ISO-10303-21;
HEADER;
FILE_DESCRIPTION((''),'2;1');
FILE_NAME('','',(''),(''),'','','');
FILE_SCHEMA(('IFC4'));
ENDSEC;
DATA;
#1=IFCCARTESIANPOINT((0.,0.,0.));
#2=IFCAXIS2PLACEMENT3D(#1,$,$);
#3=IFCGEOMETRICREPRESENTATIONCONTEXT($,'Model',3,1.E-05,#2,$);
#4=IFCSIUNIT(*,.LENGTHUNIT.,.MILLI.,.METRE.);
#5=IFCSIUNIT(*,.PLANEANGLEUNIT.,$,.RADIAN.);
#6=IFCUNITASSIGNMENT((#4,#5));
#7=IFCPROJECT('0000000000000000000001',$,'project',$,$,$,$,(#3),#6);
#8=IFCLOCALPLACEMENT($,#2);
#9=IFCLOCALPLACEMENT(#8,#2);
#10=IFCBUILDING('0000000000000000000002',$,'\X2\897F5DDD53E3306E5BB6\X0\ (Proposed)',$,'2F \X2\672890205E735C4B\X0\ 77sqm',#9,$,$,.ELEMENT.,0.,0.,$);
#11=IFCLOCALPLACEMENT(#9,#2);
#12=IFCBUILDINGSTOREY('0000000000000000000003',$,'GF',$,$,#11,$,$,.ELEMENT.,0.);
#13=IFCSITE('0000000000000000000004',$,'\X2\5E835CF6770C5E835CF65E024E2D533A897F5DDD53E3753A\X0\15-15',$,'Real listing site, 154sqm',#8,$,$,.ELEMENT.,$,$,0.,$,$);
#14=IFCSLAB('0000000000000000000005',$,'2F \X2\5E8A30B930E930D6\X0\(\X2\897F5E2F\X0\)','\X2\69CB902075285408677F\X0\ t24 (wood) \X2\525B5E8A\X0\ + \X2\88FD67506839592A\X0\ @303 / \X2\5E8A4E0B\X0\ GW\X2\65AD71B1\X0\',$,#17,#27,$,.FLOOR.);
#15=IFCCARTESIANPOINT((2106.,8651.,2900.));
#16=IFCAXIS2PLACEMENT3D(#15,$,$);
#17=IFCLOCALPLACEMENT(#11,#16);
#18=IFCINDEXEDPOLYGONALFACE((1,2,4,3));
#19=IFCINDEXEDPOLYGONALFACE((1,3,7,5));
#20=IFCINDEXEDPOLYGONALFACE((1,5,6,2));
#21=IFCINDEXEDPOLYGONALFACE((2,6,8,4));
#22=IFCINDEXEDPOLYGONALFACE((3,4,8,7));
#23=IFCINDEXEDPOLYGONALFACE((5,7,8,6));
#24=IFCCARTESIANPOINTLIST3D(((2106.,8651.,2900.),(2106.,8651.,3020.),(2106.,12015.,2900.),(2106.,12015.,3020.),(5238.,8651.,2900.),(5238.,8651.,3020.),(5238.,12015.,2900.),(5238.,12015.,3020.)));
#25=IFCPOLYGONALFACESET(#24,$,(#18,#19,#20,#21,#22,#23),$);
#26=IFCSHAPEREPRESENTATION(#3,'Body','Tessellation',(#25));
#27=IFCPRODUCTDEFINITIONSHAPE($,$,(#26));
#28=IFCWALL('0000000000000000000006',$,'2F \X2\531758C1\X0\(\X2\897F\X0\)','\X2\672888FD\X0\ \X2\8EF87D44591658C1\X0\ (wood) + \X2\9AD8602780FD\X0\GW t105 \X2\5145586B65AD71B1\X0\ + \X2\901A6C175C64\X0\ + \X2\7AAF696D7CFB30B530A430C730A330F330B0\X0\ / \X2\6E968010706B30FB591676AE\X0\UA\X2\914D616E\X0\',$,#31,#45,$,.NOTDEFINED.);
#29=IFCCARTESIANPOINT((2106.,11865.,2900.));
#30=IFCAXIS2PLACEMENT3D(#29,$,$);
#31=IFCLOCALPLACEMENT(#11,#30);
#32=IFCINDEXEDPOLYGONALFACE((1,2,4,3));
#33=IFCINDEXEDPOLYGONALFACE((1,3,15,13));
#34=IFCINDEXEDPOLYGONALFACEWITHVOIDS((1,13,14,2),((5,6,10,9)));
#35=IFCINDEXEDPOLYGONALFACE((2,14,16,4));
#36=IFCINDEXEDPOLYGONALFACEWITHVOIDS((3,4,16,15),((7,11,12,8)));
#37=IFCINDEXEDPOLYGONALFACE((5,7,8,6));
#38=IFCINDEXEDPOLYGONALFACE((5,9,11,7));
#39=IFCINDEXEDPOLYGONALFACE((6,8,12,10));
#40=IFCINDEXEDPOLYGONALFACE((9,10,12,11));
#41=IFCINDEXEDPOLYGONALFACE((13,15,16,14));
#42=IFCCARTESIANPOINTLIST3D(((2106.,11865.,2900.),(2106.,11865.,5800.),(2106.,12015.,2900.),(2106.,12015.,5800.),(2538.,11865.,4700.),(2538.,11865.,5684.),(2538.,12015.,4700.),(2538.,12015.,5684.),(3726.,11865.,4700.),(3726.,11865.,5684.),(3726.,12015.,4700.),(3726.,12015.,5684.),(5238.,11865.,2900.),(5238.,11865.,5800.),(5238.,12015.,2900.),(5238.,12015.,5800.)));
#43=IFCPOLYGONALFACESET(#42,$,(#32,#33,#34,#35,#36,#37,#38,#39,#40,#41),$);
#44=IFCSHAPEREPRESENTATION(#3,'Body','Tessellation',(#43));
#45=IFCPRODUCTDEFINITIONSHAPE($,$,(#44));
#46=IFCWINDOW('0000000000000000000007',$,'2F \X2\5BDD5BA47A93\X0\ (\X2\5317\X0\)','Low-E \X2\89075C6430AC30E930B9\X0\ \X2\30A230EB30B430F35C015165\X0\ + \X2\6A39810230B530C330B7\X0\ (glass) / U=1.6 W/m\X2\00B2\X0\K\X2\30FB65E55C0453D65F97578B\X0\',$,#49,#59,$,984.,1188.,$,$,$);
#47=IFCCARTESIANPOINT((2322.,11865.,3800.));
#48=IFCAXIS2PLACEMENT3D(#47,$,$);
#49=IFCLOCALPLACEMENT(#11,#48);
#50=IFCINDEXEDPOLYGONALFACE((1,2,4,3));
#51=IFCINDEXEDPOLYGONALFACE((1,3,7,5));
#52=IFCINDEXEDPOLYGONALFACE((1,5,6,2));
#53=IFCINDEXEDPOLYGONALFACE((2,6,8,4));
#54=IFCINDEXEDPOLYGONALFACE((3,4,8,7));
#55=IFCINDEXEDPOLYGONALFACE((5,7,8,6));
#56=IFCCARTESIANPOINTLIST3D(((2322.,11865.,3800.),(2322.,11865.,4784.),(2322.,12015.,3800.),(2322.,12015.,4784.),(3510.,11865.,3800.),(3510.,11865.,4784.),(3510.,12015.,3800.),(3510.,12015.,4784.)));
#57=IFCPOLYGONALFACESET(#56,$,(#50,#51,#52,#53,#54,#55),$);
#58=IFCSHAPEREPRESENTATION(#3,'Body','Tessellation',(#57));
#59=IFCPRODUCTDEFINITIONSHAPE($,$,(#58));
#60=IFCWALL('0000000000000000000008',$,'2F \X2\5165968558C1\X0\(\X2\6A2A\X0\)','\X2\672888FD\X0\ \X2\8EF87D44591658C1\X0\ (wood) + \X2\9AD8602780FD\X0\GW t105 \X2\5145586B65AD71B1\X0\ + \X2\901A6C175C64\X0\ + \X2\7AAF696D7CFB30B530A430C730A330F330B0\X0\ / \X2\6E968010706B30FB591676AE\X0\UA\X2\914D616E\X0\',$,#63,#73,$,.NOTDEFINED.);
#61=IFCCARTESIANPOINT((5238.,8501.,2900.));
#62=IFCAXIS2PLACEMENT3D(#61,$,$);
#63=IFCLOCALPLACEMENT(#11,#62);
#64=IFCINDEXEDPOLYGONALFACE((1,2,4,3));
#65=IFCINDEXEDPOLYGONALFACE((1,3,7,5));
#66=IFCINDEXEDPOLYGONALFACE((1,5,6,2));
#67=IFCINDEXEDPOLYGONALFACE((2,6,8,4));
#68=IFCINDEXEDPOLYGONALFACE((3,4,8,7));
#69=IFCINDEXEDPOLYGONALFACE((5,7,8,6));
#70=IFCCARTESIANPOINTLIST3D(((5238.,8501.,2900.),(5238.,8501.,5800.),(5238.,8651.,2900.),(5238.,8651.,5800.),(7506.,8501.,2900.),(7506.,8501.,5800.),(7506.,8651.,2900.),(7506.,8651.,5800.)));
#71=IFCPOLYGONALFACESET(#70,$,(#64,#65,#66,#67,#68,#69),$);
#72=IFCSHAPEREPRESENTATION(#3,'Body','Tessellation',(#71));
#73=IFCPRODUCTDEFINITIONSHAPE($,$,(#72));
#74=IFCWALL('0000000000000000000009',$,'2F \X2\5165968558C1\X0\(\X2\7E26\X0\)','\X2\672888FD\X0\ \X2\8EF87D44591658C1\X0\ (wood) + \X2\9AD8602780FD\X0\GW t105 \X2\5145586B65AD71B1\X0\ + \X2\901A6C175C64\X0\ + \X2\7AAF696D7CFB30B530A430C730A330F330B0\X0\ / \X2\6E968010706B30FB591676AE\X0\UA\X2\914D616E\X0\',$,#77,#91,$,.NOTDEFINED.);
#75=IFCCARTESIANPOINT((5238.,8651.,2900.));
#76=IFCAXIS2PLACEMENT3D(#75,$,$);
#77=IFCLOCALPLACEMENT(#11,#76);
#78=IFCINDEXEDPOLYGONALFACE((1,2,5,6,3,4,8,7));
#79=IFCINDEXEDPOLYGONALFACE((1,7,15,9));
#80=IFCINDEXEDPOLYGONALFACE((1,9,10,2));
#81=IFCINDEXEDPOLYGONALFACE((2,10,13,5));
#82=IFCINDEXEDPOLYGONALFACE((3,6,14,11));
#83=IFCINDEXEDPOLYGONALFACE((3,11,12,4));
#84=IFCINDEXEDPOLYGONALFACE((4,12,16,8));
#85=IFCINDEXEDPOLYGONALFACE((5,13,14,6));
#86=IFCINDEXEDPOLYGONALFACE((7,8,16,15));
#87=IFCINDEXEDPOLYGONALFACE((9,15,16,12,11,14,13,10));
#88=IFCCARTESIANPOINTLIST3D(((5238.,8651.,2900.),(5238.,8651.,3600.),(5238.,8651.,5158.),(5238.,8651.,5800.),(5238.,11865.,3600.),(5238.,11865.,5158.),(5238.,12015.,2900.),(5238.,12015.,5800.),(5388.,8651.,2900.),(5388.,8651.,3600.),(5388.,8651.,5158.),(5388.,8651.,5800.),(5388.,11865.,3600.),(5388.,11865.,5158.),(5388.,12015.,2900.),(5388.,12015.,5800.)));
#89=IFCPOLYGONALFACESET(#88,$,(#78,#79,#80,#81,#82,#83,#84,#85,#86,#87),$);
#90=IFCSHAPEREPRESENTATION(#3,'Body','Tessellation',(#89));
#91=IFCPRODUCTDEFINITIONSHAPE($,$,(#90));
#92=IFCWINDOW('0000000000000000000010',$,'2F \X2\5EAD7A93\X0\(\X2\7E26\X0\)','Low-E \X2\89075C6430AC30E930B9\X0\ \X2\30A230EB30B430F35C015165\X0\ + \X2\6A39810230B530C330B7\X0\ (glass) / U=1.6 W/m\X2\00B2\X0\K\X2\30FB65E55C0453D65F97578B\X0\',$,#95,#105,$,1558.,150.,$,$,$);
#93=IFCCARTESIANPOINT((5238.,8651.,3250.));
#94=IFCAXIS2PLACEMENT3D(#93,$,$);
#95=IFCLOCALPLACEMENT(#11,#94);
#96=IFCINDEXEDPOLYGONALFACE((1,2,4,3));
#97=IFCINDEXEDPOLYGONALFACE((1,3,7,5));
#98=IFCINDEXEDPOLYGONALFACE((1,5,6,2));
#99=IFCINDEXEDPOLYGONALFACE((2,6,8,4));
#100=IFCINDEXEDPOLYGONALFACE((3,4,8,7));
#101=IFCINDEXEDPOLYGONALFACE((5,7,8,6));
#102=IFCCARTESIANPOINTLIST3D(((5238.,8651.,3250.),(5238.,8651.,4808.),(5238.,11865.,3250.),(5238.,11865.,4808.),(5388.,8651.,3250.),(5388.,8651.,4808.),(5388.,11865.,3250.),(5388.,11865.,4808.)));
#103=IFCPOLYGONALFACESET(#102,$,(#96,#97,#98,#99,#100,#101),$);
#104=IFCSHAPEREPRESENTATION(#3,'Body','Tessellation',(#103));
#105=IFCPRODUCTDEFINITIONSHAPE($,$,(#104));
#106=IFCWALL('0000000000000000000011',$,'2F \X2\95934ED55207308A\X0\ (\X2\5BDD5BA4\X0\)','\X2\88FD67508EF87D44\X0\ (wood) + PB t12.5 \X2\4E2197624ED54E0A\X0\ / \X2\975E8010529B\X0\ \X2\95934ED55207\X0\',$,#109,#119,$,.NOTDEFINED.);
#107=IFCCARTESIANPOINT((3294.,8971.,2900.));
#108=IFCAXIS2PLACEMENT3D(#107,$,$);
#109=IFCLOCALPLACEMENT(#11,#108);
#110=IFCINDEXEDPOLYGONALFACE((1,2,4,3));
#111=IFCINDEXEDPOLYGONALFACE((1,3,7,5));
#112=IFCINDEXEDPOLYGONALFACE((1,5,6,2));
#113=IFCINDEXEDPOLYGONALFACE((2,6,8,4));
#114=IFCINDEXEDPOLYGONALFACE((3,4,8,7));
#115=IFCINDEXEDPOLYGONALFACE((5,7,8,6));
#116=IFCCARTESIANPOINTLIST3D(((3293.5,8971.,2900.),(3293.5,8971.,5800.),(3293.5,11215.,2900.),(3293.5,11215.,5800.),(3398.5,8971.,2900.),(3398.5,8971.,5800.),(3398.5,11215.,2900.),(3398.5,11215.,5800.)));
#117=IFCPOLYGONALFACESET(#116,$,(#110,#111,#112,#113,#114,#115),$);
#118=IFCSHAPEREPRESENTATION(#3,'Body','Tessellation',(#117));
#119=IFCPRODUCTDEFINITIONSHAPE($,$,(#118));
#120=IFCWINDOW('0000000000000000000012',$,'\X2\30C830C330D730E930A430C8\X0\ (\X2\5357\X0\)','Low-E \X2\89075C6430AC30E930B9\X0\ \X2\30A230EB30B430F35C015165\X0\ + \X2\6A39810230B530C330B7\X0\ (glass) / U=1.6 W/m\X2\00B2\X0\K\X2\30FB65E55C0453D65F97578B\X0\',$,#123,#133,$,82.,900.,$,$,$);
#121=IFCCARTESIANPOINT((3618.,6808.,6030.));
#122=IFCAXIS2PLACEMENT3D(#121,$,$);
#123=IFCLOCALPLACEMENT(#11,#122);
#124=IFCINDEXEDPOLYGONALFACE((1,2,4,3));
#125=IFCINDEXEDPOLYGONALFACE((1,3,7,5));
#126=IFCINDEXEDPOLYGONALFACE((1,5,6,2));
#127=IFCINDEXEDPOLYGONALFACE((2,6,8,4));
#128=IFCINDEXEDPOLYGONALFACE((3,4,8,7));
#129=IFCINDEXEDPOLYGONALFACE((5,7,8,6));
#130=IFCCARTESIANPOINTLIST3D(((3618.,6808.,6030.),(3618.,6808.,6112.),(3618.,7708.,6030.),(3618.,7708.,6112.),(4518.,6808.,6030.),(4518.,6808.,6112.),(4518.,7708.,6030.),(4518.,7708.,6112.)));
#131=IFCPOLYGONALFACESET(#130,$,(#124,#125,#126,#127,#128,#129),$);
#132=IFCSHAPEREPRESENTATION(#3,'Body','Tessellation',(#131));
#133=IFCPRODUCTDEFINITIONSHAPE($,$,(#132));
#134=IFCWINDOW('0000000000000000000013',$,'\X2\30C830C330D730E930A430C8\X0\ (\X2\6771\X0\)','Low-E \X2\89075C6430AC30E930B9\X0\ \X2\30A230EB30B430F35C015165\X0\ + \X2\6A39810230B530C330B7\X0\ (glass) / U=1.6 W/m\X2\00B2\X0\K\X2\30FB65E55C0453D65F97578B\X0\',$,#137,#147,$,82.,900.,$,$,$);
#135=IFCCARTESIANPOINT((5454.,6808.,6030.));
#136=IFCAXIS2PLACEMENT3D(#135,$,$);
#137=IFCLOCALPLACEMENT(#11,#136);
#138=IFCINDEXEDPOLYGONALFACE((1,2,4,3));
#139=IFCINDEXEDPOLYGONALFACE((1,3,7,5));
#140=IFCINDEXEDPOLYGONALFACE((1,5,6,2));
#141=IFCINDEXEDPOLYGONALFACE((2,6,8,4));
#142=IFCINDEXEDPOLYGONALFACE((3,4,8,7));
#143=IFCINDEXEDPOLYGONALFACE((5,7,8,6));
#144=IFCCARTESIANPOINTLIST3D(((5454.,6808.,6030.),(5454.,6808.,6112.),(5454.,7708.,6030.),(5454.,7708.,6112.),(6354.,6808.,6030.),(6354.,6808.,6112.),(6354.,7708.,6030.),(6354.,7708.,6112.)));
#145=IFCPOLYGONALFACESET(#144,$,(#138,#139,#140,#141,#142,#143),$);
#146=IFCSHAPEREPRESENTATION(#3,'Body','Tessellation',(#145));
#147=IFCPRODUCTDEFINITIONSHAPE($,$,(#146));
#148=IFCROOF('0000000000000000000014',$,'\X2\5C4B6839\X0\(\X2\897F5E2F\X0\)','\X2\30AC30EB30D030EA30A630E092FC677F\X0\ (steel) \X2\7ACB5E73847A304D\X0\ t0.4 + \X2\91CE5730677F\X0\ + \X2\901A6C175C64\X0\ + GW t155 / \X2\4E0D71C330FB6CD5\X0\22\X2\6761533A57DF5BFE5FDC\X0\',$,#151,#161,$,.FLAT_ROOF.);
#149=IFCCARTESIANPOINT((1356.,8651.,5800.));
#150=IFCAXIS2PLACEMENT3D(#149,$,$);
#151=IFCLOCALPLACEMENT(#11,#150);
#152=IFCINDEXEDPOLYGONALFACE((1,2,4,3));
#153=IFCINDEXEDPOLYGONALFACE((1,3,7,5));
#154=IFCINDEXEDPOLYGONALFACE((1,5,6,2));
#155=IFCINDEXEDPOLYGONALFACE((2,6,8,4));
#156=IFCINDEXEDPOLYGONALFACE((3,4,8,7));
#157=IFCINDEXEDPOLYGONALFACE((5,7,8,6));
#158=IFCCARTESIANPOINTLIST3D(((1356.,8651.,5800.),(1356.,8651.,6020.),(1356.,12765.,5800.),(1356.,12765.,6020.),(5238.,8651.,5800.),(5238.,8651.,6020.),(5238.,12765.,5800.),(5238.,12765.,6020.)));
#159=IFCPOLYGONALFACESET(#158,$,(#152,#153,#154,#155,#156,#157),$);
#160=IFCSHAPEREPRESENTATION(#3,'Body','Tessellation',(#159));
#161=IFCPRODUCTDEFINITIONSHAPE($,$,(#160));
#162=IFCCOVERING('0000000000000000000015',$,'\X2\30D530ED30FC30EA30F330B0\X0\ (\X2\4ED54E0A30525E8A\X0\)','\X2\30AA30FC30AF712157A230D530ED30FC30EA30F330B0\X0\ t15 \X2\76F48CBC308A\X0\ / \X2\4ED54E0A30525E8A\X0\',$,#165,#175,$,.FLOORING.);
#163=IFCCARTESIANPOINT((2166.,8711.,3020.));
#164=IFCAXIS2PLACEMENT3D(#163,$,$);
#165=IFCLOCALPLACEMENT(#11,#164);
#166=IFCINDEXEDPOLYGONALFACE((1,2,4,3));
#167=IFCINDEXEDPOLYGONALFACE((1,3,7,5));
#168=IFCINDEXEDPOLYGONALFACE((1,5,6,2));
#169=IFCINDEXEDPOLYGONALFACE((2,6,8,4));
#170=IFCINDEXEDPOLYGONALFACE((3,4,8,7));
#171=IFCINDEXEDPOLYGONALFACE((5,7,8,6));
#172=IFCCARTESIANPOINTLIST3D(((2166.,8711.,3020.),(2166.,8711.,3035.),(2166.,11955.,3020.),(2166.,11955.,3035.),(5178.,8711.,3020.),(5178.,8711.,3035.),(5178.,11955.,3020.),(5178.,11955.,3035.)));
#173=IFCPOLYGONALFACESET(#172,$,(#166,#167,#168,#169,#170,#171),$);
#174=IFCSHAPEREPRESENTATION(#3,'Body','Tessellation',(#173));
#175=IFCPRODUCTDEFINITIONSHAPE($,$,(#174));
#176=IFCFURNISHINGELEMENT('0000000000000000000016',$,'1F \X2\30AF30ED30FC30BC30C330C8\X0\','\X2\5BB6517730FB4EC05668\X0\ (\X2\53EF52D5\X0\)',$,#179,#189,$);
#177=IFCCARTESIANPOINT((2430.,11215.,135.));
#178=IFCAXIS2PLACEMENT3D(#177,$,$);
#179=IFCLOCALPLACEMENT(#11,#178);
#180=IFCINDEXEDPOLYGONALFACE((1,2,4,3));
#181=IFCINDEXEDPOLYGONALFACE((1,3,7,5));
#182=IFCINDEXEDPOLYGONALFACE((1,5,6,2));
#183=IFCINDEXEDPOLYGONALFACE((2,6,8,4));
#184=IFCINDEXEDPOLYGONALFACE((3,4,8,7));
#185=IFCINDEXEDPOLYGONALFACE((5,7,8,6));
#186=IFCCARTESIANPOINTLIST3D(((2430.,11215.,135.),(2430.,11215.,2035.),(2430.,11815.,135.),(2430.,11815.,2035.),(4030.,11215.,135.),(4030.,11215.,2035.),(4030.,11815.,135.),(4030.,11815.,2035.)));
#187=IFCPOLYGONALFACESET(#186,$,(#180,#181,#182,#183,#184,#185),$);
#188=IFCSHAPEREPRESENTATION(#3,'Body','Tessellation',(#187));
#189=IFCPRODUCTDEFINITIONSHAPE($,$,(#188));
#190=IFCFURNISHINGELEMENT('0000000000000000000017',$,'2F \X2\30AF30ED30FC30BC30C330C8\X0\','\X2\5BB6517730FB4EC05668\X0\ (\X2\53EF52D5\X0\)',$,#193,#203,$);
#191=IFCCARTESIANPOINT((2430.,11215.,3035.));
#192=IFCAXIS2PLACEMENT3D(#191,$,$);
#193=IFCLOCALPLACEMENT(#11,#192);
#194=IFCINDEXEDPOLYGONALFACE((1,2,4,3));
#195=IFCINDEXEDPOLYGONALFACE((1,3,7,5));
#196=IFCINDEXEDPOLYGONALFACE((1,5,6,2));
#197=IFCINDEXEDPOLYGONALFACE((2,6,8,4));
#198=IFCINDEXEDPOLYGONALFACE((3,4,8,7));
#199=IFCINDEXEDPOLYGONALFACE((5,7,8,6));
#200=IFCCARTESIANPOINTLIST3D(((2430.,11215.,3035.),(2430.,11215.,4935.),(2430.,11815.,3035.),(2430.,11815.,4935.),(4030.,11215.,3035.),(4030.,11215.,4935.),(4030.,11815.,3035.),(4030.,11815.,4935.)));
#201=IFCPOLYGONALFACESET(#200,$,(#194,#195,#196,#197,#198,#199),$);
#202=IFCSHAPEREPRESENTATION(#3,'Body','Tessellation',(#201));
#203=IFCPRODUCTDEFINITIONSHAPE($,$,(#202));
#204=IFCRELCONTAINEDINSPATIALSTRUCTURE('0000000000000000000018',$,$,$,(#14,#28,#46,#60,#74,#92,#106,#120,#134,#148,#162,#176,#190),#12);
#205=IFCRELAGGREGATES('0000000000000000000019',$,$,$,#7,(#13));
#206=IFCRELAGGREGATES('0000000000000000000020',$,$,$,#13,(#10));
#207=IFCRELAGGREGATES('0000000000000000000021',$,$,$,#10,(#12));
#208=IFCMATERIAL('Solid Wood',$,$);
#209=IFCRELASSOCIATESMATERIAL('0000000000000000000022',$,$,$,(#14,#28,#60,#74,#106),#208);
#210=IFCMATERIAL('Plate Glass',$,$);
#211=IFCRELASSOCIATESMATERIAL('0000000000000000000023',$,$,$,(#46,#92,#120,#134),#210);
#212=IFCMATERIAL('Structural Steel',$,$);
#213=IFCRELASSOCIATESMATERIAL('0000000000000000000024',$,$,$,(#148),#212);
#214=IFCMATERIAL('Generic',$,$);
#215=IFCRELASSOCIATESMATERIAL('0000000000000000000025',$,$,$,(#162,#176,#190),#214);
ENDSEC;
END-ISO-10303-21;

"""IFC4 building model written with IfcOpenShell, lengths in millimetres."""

from ifc_helpers import new_model, si_unit, frame, frame_2d, origin, place, context, project, spatial, rectangle, extrude, material, element, fill, save


model = new_model("IFC4")

# Units and contexts
model_context = context("Model", 3, precision=1e-05, world=origin())
ifc_project = project(units=[si_unit("LENGTHUNIT", "METRE", prefix="MILLI"), si_unit("PLANEANGLEUNIT", "RADIAN")], contexts=[model_context])

# Site, building, storey
site_placement = place(None, origin())
site = spatial("IfcSite", under=ifc_project, at=site_placement, Name="広島県広島市中区西川口町15-15", ObjectType="Real listing site, 154sqm", CompositionType="ELEMENT", RefElevation=0.0)
building_placement = place(site_placement, origin())
building = spatial("IfcBuilding", under=site, at=building_placement, Name="西川口の家 (Proposed)", ObjectType="2F 木造平屋 77sqm", CompositionType="ELEMENT", ElevationOfRefHeight=0.0, ElevationOfTerrain=0.0)
storey_placement = place(building_placement, origin())
storey = spatial("IfcBuildingStorey", under=building, at=storey_placement, Name="GF", CompositionType="ELEMENT", Elevation=0.0)

# Slab
ifc_material_1 = material(Name="Solid Wood")
slab_placement = place(storey_placement, frame((2106.0, 8651.0, 2900.0)))
element("IfcSlab", 1, at=slab_placement, inside=storey, material=ifc_material_1, Name="2F 床スラブ(西帯)", Description="構造用合板 t24 (wood) 剛床 + 製材根太 @303 / 床下 GW断熱", PredefinedType="FLOOR", context=model_context, shape_type="SweptSolid", body=[
    extrude(rectangle(XDim=3132.0, YDim=3364.0, at=frame_2d((1566.0, 1682.0))), frame((2106.0, 8651.0, 2900.0)), (0.0, 0.0, 1.0), 120.0),
])

# Wall, opening, window
wall_1_placement = place(storey_placement, frame((2106.0, 11865.0, 2900.0)))
wall_1 = element("IfcWall", 2, at=wall_1_placement, inside=storey, material=ifc_material_1, Name="2F 北壁(西)", Description="木製 軸組外壁 (wood) + 高性能GW t105 充填断熱 + 通気層 + 窯業系サイディング / 準耐火・外皮UA配慮", PredefinedType="NOTDEFINED", context=model_context, shape_type="SweptSolid", body=[
    extrude(rectangle(XDim=3132.0, YDim=150.0, at=frame_2d((1566.0, 75.0))), frame((2106.0, 11865.0, 2900.0)), (0.0, 0.0, 1.0), 2900.0),
])
opening_1_placement = place(storey_placement, frame((2322.0, 11865.0, 3800.0)))
opening_1 = element("IfcOpeningElement", 3, at=opening_1_placement, cuts=wall_1, PredefinedType="NOTDEFINED", context=model_context, shape_type="SweptSolid", body=[
    extrude(rectangle(XDim=1188.0, YDim=150.0, at=frame_2d((594.0, 75.0))), frame((2322.0, 11865.0, 3800.0)), (0.0, 0.0, 1.0), 984.0),
])
ifc_material_2 = material(Name="Plate Glass")
window_1_placement = place(storey_placement, frame((2322.0, 11865.0, 3800.0)))
window_1 = element("IfcWindow", 4, at=window_1_placement, inside=storey, material=ifc_material_2, Name="2F 寝室窓 (北)", Description="Low-E 複層ガラス アルゴン封入 + 樹脂サッシ (glass) / U=1.6 W/m²K・日射取得型", OverallHeight=984.0, OverallWidth=1188.0, context=model_context, shape_type="SweptSolid", body=[
    extrude(rectangle(XDim=1188.0, YDim=150.0, at=frame_2d((594.0, 75.0))), frame((2322.0, 11865.0, 3800.0)), (0.0, 0.0, 1.0), 984.0),
])
fill(opening_1, window_1)

# Wall
wall_2_placement = place(storey_placement, frame((5238.0, 8501.0, 2900.0)))
element("IfcWall", 5, at=wall_2_placement, inside=storey, material=ifc_material_1, Name="2F 入隅壁(横)", Description="木製 軸組外壁 (wood) + 高性能GW t105 充填断熱 + 通気層 + 窯業系サイディング / 準耐火・外皮UA配慮", PredefinedType="NOTDEFINED", context=model_context, shape_type="SweptSolid", body=[
    extrude(rectangle(XDim=2268.0, YDim=150.0, at=frame_2d((1134.0, 75.0))), frame((5238.0, 8501.0, 2900.0)), (0.0, 0.0, 1.0), 2900.0),
])

# Wall, opening, window
wall_3_placement = place(storey_placement, frame((5238.0, 8651.0, 2900.0)))
wall_3 = element("IfcWall", 6, at=wall_3_placement, inside=storey, material=ifc_material_1, Name="2F 入隅壁(縦)", Description="木製 軸組外壁 (wood) + 高性能GW t105 充填断熱 + 通気層 + 窯業系サイディング / 準耐火・外皮UA配慮", PredefinedType="NOTDEFINED", context=model_context, shape_type="SweptSolid", body=[
    extrude(rectangle(XDim=150.0, YDim=3364.0, at=frame_2d((75.0, 1682.0))), frame((5238.0, 8651.0, 2900.0)), (0.0, 0.0, 1.0), 2900.0),
])
opening_2_placement = place(storey_placement, frame((5238.0, 8651.0, 3250.0)))
opening_2 = element("IfcOpeningElement", 7, at=opening_2_placement, cuts=wall_3, PredefinedType="NOTDEFINED", context=model_context, shape_type="SweptSolid", body=[
    extrude(rectangle(XDim=150.0, YDim=3214.0, at=frame_2d((75.0, 1607.0))), frame((5238.0, 8651.0, 3250.0)), (0.0, 0.0, 1.0), 1558.0),
])
window_2_placement = place(storey_placement, frame((5238.0, 8651.0, 3250.0)))
window_2 = element("IfcWindow", 8, at=window_2_placement, inside=storey, material=ifc_material_2, Name="2F 庭窓(縦)", Description="Low-E 複層ガラス アルゴン封入 + 樹脂サッシ (glass) / U=1.6 W/m²K・日射取得型", OverallHeight=1558.0, OverallWidth=150.0, context=model_context, shape_type="SweptSolid", body=[
    extrude(rectangle(XDim=150.0, YDim=3214.0, at=frame_2d((75.0, 1607.0))), frame((5238.0, 8651.0, 3250.0)), (0.0, 0.0, 1.0), 1558.0),
])
fill(opening_2, window_2)

# Wall
wall_4_placement = place(storey_placement, frame((3294.0, 8971.0, 2900.0)))
element("IfcWall", 9, at=wall_4_placement, inside=storey, material=ifc_material_1, Name="2F 間仕切り (寝室)", Description="製材軸組 (wood) + PB t12.5 両面仕上 / 非耐力 間仕切", PredefinedType="NOTDEFINED", context=model_context, shape_type="SweptSolid", body=[
    extrude(rectangle(XDim=105.0, YDim=2244.0, at=frame_2d((52.0, 1122.0))), frame((3294.0, 8971.0, 2900.0)), (0.0, 0.0, 1.0), 2900.0),
])

# Windows
window_3_placement = place(storey_placement, frame((3618.0, 6808.0, 6030.0)))
element("IfcWindow", 10, at=window_3_placement, inside=storey, material=ifc_material_2, Name="トップライト (南)", Description="Low-E 複層ガラス アルゴン封入 + 樹脂サッシ (glass) / U=1.6 W/m²K・日射取得型", OverallHeight=82.0, OverallWidth=900.0, context=model_context, shape_type="SweptSolid", body=[
    extrude(rectangle(XDim=900.0, YDim=900.0, at=frame_2d((450.0, 450.0))), frame((3618.0, 6808.0, 6030.0)), (0.0, 0.0, 1.0), 82.0),
])
window_4_placement = place(storey_placement, frame((5454.0, 6808.0, 6030.0)))
element("IfcWindow", 11, at=window_4_placement, inside=storey, material=ifc_material_2, Name="トップライト (東)", Description="Low-E 複層ガラス アルゴン封入 + 樹脂サッシ (glass) / U=1.6 W/m²K・日射取得型", OverallHeight=82.0, OverallWidth=900.0, context=model_context, shape_type="SweptSolid", body=[
    extrude(rectangle(XDim=900.0, YDim=900.0, at=frame_2d((450.0, 450.0))), frame((5454.0, 6808.0, 6030.0)), (0.0, 0.0, 1.0), 82.0),
])

# Roof
ifc_material_3 = material(Name="Structural Steel")
for number, where, name in (
    (12, (1356.0, 8651.0, 5800.0), "屋根(西帯)"),
):
    element("IfcRoof", number, at=place(storey_placement, frame(where)), inside=storey, material=ifc_material_3, Name=name, Description="ガルバリウム鋼板 (steel) 立平葺き t0.4 + 野地板 + 通気層 + GW t155 / 不燃・法22条区域対応", PredefinedType="FLAT_ROOF", context=model_context, shape_type="SweptSolid", body=[
        extrude(rectangle(XDim=3882.0, YDim=4114.0, at=frame_2d((1941.0, 2057.0))), frame((1356.0, 8651.0, 5800.0)), (0.0, 0.0, 1.0), 220.0),
    ])

# Covering
ifc_material_4 = material(Name="Generic")
covering_placement = place(storey_placement, frame((2166.0, 8711.0, 3020.0)))
element("IfcCovering", 13, at=covering_placement, inside=storey, material=ifc_material_4, Name="フローリング (仕上げ床)", Description="オーク無垢フローリング t15 直貼り / 仕上げ床", PredefinedType="FLOORING", context=model_context, shape_type="SweptSolid", body=[
    extrude(rectangle(XDim=3012.0, YDim=3244.0, at=frame_2d((1506.0, 1622.0))), frame((2166.0, 8711.0, 3020.0)), (0.0, 0.0, 1.0), 15.0),
])

# Furnishing elements
furnishing_1_placement = place(storey_placement, frame((2430.0, 11215.0, 135.0)))
element("IfcFurnishingElement", 14, at=furnishing_1_placement, inside=storey, material=ifc_material_4, Name="1F クローゼット", Description="家具・什器 (可動)", context=model_context, shape_type="SweptSolid", body=[
    extrude(rectangle(XDim=1600.0, YDim=600.0, at=frame_2d((800.0, 300.0))), frame((2430.0, 11215.0, 135.0)), (0.0, 0.0, 1.0), 1900.0),
])
furnishing_2_placement = place(storey_placement, frame((2430.0, 11215.0, 3035.0)))
element("IfcFurnishingElement", 15, at=furnishing_2_placement, inside=storey, material=ifc_material_4, Name="2F クローゼット", Description="家具・什器 (可動)", context=model_context, shape_type="SweptSolid", body=[
    extrude(rectangle(XDim=1600.0, YDim=600.0, at=frame_2d((800.0, 300.0))), frame((2430.0, 11215.0, 3035.0)), (0.0, 0.0, 1.0), 1900.0),
])

save(model, "model.ifc")
